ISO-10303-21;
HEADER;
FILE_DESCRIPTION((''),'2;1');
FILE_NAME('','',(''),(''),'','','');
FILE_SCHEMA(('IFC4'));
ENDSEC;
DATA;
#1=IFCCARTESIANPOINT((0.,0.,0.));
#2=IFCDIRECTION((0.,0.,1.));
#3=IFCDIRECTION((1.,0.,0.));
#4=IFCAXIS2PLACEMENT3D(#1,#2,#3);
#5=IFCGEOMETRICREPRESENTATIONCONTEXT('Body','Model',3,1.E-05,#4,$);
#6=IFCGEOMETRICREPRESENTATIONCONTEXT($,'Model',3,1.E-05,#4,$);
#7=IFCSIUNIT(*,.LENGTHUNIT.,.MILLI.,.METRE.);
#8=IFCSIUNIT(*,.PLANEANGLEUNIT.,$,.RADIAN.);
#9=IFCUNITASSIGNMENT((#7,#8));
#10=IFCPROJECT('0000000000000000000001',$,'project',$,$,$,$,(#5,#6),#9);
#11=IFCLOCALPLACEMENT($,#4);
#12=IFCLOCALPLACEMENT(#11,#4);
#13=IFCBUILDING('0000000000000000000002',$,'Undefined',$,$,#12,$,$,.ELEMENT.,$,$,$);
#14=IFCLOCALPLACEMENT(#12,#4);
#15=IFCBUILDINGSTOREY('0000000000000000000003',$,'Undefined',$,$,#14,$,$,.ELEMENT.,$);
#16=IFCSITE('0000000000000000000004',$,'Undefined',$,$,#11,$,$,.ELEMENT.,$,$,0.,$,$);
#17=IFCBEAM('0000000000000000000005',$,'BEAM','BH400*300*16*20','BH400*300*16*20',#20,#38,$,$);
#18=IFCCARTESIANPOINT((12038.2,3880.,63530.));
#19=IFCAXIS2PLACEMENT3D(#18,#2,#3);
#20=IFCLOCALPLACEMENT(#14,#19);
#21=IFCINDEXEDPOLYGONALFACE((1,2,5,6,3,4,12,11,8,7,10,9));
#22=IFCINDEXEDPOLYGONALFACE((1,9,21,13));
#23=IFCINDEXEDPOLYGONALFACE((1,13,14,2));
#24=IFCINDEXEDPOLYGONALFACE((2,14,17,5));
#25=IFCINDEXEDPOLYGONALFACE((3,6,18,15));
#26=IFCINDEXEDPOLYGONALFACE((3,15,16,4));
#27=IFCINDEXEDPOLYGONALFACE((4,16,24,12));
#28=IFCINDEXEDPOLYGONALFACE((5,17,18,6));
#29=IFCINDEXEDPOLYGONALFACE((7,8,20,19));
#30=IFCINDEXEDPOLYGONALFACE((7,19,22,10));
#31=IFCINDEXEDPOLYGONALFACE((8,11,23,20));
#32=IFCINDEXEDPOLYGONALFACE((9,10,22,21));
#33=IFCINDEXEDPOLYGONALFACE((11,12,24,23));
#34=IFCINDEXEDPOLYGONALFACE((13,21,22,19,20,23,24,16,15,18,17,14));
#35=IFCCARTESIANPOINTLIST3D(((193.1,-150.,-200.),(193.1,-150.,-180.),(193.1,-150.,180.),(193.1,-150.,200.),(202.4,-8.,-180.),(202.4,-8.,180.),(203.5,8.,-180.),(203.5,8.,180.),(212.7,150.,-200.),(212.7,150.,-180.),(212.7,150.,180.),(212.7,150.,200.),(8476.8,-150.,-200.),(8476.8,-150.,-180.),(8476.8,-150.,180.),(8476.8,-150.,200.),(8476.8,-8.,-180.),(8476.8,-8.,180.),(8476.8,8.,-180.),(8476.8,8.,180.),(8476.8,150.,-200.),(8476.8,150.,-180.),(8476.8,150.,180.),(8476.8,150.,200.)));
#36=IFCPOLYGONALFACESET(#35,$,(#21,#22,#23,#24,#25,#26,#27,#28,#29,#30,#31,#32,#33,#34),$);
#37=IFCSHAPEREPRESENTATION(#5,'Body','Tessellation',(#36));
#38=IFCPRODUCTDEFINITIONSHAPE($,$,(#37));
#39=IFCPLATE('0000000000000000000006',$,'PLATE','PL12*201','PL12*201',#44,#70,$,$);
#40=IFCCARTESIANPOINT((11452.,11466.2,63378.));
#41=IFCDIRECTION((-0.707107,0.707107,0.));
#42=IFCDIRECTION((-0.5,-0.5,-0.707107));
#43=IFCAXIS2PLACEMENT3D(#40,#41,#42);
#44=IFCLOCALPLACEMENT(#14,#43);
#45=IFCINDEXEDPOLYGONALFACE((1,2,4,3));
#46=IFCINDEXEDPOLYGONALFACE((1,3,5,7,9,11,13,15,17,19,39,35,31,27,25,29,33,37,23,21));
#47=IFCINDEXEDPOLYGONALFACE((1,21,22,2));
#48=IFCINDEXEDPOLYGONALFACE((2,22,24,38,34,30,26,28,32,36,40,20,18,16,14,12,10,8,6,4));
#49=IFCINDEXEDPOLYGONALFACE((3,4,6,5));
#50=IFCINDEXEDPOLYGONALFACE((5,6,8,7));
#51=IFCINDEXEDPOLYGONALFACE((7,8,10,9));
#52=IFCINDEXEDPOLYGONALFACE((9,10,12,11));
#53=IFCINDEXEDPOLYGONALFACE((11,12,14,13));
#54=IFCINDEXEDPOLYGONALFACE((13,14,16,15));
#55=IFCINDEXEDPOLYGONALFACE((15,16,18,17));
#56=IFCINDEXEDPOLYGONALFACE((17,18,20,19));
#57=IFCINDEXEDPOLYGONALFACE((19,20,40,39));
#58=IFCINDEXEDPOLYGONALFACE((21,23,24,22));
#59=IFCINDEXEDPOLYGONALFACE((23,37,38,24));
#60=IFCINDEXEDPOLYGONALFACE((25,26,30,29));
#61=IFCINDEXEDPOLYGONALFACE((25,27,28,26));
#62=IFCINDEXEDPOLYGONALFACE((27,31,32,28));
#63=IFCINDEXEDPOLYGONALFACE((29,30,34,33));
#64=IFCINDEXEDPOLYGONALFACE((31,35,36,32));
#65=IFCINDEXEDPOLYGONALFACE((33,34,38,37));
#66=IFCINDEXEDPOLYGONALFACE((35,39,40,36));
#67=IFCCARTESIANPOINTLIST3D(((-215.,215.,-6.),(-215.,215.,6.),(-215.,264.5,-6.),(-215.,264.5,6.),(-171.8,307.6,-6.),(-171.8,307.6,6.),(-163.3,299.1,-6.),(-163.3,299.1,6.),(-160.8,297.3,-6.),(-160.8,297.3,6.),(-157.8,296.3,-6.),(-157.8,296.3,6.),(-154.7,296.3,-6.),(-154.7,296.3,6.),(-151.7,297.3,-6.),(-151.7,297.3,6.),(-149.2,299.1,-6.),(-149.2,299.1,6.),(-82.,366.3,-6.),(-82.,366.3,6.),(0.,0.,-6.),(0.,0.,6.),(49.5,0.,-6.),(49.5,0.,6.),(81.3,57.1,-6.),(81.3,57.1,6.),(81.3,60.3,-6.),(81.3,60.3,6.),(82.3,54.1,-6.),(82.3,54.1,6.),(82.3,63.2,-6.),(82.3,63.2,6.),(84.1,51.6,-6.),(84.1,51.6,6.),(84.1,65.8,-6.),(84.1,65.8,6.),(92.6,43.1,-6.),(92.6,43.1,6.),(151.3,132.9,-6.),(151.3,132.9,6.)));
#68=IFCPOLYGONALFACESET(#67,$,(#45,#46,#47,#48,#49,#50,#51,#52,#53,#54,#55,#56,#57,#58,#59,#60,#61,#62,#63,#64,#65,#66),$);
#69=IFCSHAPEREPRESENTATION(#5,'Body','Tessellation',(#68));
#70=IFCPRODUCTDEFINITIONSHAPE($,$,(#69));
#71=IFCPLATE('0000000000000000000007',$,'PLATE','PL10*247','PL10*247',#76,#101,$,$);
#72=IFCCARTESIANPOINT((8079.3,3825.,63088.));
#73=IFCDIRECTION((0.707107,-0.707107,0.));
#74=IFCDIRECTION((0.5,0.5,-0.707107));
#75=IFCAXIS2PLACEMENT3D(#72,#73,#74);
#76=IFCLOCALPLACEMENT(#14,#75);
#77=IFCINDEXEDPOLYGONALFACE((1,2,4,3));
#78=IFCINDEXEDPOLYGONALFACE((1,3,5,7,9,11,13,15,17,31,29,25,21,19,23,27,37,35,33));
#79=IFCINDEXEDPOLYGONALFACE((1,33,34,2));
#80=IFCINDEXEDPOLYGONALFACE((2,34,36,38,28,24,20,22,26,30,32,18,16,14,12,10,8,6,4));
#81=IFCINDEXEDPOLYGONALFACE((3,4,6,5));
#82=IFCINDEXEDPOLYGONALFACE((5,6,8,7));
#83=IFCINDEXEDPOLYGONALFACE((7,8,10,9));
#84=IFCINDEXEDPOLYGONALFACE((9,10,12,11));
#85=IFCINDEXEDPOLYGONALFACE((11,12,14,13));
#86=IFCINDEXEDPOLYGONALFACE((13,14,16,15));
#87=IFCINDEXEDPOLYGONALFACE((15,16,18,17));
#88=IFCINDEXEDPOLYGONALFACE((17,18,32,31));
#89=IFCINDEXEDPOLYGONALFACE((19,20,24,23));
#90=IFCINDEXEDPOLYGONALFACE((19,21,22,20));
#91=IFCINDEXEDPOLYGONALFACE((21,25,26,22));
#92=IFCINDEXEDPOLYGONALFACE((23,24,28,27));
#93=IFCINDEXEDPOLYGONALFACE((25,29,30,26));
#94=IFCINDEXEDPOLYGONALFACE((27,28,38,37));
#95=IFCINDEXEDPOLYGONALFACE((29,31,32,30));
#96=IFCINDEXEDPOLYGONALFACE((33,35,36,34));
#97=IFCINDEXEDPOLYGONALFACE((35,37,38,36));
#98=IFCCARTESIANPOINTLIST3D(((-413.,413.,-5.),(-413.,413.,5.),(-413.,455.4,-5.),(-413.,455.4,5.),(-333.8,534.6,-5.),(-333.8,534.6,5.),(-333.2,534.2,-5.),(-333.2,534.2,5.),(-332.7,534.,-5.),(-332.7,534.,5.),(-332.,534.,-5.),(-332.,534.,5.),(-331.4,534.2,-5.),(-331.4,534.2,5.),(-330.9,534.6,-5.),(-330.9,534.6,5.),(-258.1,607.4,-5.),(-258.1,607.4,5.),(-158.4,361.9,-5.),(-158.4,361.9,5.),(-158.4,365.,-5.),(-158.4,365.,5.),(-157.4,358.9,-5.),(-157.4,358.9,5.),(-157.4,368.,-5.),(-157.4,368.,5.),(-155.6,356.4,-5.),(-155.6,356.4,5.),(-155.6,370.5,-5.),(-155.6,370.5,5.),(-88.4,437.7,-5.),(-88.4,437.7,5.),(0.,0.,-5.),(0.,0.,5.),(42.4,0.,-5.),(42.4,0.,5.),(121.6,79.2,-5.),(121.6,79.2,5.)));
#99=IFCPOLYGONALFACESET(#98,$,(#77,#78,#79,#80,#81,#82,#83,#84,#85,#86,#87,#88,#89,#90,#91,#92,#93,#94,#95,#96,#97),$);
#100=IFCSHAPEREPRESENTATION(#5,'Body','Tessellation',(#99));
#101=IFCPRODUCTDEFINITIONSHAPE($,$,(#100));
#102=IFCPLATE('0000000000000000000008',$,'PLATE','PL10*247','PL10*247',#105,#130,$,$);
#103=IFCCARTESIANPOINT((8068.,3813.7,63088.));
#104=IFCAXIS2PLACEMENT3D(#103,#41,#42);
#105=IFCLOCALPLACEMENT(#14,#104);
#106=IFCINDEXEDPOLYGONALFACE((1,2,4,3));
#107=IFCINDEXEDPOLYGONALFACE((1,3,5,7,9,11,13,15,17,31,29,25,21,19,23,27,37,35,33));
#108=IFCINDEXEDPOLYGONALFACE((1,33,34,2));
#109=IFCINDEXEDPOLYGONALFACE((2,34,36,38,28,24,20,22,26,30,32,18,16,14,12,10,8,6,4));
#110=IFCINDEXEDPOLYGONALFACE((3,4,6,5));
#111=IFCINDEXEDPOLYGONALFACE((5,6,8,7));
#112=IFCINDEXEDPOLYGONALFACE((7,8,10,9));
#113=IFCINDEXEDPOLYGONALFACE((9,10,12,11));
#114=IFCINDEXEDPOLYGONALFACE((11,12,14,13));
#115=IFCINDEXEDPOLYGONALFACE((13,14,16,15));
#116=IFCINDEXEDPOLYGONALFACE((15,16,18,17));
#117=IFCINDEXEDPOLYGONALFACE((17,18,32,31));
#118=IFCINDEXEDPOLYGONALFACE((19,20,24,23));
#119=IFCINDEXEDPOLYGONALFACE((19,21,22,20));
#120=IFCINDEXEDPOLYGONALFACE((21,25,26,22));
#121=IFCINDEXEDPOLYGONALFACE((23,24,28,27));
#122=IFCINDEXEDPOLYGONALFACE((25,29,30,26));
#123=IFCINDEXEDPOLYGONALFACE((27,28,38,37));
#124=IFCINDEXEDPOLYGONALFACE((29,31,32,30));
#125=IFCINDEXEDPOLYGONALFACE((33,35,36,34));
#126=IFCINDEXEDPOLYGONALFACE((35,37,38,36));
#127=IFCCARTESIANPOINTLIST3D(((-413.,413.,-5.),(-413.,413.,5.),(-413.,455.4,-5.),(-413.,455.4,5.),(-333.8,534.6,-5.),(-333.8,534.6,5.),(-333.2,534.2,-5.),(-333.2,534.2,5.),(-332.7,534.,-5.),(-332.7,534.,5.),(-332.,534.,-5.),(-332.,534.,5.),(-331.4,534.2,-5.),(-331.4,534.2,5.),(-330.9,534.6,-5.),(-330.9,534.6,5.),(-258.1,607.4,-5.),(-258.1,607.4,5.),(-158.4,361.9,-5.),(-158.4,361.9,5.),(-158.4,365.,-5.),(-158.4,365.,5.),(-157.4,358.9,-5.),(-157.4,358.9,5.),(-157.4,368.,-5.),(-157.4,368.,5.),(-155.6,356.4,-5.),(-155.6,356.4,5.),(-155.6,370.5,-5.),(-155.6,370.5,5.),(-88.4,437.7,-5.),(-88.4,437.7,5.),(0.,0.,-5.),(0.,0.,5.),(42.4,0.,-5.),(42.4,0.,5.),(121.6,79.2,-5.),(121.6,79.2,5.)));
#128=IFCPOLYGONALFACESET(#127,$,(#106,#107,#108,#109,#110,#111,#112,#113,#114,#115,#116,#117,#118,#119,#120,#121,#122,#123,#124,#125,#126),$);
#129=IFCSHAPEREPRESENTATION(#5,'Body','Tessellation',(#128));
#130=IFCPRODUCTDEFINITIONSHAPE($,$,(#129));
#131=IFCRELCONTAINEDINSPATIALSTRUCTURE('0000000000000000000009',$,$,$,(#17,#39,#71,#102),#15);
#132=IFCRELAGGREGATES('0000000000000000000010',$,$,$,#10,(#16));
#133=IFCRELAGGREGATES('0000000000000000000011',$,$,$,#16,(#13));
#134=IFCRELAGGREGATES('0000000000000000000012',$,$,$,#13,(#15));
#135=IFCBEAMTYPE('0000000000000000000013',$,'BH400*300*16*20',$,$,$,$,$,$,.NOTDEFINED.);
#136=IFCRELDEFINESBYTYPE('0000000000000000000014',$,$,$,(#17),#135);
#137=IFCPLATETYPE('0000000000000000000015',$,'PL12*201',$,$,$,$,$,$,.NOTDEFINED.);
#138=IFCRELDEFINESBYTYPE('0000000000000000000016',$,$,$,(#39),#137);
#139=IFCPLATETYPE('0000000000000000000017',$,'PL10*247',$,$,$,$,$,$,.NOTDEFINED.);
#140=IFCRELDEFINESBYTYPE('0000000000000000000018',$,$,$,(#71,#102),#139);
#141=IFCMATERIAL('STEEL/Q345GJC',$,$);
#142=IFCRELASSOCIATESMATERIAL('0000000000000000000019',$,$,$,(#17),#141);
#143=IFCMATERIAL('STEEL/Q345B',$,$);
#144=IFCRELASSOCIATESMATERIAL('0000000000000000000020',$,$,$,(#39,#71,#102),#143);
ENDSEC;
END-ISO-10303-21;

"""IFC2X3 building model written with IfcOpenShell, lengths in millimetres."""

from ifc_helpers import new_model, si_unit, frame, origin_with_axes, origin_2d_with_axis, place, context, project, spatial, polyline, i_section, outline, extrude, clip, halfspace, material, type_object, element, save


model = new_model("IFC2X3")

# Units and contexts
model_context_1 = context("Model", 3, precision=1e-05, world=origin_with_axes(), identifier="Body")
model_context_2 = context("Model", 3, precision=1e-05, world=origin_with_axes())
ifc_project = project(units=[si_unit("LENGTHUNIT", "METRE", prefix="MILLI"), si_unit("PLANEANGLEUNIT", "RADIAN")], contexts=[model_context_1, model_context_2])

# Site, building, storey
site_placement = place(None, origin_with_axes())
site = spatial("IfcSite", under=ifc_project, at=site_placement, Name="Undefined", CompositionType="ELEMENT", RefElevation=0.0)
building_placement = place(site_placement, origin_with_axes())
building = spatial("IfcBuilding", under=site, at=building_placement, Name="Undefined", CompositionType="ELEMENT")
storey_placement = place(building_placement, origin_with_axes())
storey = spatial("IfcBuildingStorey", under=building, at=storey_placement, Name="Undefined", CompositionType="ELEMENT")

# Beam
ifc_material_1 = material(Name="STEEL/Q345B")
ifc_material_2 = material(Name="STEEL/Q345GJC")
beam_type_1 = type_object("IfcBeamType", Name="BH400*300*16*20", PredefinedType="NOTDEFINED")
beam_1_placement = place(storey_placement, frame((12038.2, 3880.0, 63530.0), z_axis=(0.0, 0.0, 1.0), x_axis=(1.0, 0.0, 0.0)))
element("IfcBeam", 1, at=beam_1_placement, inside=storey, type_object=beam_type_1, material=ifc_material_2, Name="BEAM", Description="BH400*300*16*20", ObjectType="BH400*300*16*20", context=model_context_1, shape_type="Clipping", body=[
    clip(clip(extrude(i_section(OverallWidth=300.0, OverallDepth=400.0, WebThickness=16.0, FlangeThickness=20.0, at=origin_2d_with_axis()), frame((8476.8, 0.0, 0.0), z_axis=(-1.0, 0.0, 0.0), x_axis=(0.0, -1.0, 0.0)), (0.0, 0.0, 1.0), 8283.8), halfspace(frame((8476.8, -70.8, 200.0), z_axis=(-1.0, 0.0, 0.0), x_axis=(0.0, 1.0, 0.0)), True)), halfspace(frame((202.1, -13.2, 300.0), z_axis=(-0.997873, 0.065184, 0.0), x_axis=(0.0, 0.0, -1.0)), False)),
])

# Plates
plate_type_1 = type_object("IfcPlateType", Name="PL12*201", PredefinedType="NOTDEFINED")
plate_1_placement = place(storey_placement, frame((11452.0, 11466.2, 63378.0), z_axis=(-0.707107, 0.707107, 0.0), x_axis=(-0.5, -0.5, -0.707107)))
element("IfcPlate", 2, at=plate_1_placement, inside=storey, type_object=plate_type_1, material=ifc_material_1, Name="PLATE", Description="PL12*201", ObjectType="PL12*201", context=model_context_1, shape_type="SweptSolid", body=[
    extrude(outline(polyline([(0.0, 0.0), (49.5, 0.0), (92.6, 43.1), (84.1, 51.6), (82.3, 54.1), (81.3, 57.1), (81.3, 60.3), (82.3, 63.2), (84.1, 65.8), (151.3, 132.9), (-82.0, 366.3), (-149.2, 299.1), (-151.7, 297.3), (-154.7, 296.3), (-157.8, 296.3), (-160.8, 297.3), (-163.3, 299.1), (-171.8, 307.6), (-215.0, 264.5), (-215.0, 215.0), (0.0, 0.0)])), frame((0.0, 0.0, -6.0), z_axis=(0.0, 0.0, 1.0), x_axis=(1.0, 0.0, 0.0)), (0.0, 0.0, 1.0), 12.0),
])
plate_type_2 = type_object("IfcPlateType", Name="PL10*247", PredefinedType="NOTDEFINED")
for number, where, z_axis, x_axis, name in (
    (3, (8079.3, 3825.0, 63088.0), (0.707107, -0.707107, 0.0), (0.5, 0.5, -0.707107), "PLATE"),
    (4, (8068.0, 3813.7, 63088.0), (-0.707107, 0.707107, 0.0), (-0.5, -0.5, -0.707107), "PLATE"),
):
    element("IfcPlate", number, at=place(storey_placement, frame(where, z_axis=z_axis, x_axis=x_axis)), inside=storey, type_object=plate_type_2, material=ifc_material_1, Name=name, Description="PL10*247", ObjectType="PL10*247", context=model_context_1, shape_type="SweptSolid", body=[
        extrude(outline(polyline([(0.0, 0.0), (42.4, 0.0), (121.6, 79.2), (-155.6, 356.4), (-157.4, 358.9), (-158.4, 361.9), (-158.4, 365.0), (-157.4, 368.0), (-155.6, 370.5), (-88.4, 437.7), (-258.1, 607.4), (-330.9, 534.6), (-331.4, 534.2), (-332.0, 534.0), (-332.7, 534.0), (-333.2, 534.2), (-333.8, 534.6), (-413.0, 455.4), (-413.0, 413.0), (0.0, 0.0)])), frame((0.0, 0.0, -5.0), z_axis=(0.0, 0.0, 1.0), x_axis=(1.0, 0.0, 0.0)), (0.0, 0.0, 1.0), 10.0),
    ])

save(model, "model.ifc")
